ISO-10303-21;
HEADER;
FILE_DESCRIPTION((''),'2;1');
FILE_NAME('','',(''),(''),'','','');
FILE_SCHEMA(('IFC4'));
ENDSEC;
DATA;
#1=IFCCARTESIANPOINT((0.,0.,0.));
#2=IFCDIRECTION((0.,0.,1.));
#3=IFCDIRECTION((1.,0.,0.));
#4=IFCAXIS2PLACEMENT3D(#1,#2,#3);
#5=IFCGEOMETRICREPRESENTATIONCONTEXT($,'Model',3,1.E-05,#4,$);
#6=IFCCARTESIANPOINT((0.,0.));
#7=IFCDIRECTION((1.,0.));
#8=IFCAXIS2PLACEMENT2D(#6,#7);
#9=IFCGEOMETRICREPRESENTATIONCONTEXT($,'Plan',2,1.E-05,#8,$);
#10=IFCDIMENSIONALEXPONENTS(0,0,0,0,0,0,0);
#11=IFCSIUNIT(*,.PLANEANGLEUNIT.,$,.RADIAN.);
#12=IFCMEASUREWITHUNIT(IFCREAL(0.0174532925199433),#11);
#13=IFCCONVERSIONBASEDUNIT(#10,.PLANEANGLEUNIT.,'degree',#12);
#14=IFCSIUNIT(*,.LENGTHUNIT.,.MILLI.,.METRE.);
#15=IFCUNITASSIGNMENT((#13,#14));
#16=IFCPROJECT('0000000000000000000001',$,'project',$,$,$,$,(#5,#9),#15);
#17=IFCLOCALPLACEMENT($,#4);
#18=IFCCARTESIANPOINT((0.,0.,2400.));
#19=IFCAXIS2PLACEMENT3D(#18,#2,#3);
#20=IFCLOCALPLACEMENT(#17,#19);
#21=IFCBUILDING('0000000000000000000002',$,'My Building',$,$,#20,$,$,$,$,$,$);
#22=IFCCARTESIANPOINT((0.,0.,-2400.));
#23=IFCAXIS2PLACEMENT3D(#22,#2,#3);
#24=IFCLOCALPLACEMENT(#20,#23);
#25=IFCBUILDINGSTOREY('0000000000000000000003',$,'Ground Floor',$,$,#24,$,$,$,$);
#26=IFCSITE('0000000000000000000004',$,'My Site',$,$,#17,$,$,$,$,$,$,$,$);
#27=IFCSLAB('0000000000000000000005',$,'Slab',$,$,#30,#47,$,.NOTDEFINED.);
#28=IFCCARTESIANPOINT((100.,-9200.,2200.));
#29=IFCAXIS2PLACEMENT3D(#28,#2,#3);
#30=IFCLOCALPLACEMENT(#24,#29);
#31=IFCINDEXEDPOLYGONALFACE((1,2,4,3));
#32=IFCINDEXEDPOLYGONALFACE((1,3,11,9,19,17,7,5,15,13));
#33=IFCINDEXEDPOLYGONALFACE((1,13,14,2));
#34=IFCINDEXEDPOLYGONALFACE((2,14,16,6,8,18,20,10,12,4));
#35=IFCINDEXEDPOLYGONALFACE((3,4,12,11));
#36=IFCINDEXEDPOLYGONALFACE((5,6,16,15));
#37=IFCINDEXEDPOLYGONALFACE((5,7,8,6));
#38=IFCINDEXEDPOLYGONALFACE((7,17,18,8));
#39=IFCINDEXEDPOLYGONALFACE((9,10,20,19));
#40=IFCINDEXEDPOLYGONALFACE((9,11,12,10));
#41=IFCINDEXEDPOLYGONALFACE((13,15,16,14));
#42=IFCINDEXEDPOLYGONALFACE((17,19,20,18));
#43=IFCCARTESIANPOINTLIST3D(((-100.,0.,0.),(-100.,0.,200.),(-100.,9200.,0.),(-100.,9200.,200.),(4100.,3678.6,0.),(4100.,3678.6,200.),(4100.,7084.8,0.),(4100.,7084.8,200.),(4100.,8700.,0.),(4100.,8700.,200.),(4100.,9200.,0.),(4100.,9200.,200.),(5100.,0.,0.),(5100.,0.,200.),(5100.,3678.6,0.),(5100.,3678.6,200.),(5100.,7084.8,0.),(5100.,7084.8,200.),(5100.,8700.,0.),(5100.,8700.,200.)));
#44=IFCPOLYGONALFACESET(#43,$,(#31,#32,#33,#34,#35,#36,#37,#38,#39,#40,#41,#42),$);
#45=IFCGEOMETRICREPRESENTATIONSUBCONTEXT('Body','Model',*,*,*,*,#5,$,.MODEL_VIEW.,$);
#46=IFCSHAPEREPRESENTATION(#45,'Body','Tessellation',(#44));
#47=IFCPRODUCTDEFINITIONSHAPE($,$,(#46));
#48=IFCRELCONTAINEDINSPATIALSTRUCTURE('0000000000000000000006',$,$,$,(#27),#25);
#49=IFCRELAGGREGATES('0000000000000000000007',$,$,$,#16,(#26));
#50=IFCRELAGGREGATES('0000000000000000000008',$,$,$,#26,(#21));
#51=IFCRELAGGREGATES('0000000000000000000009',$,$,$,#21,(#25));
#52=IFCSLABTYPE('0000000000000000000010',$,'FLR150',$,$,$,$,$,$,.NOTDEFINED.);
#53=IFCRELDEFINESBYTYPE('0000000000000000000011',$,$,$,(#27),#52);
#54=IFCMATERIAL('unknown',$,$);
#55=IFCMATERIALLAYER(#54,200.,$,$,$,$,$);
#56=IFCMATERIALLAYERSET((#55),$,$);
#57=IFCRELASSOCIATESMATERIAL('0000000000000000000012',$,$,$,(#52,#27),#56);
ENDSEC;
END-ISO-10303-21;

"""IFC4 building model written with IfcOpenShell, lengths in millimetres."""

from ifc_helpers import new_model, entity, si_unit, converted_unit, frame, origin_with_axes, origin_2d_with_axis, place, context, subcontext, project, spatial, line, indexed_curve, outline, extrude, material, layer, layer_set, layer_usage, type_object, element, save


model = new_model("IFC4")

# Units and contexts
model_context = context("Model", 3, precision=1e-05, world=origin_with_axes())
plan_context = context("Plan", 2, precision=1e-05, world=origin_2d_with_axis())
body_context = subcontext(model_context, "Body", "Model", "MODEL_VIEW")
ifc_project = project(units=[converted_unit("PLANEANGLEUNIT", "degree", entity("IfcReal", 0.0174532925199433), si_unit("PLANEANGLEUNIT", "RADIAN"), dimensions=[0, 0, 0, 0, 0, 0, 0]), si_unit("LENGTHUNIT", "METRE", prefix="MILLI")], contexts=[model_context, plan_context])

# Site, building, storey
site_placement = place(None, origin_with_axes())
site = spatial("IfcSite", under=ifc_project, at=site_placement, Name="My Site")
building_placement = place(site_placement, frame((0.0, 0.0, 2400.0), z_axis=(0.0, 0.0, 1.0), x_axis=(1.0, 0.0, 0.0)))
building = spatial("IfcBuilding", under=site, at=building_placement, Name="My Building")
storey_placement = place(building_placement, frame((0.0, 0.0, -2400.0), z_axis=(0.0, 0.0, 1.0), x_axis=(1.0, 0.0, 0.0)))
storey = spatial("IfcBuildingStorey", under=building, at=storey_placement, Name="Ground Floor")

# Slab
ifc_material = material(Name="unknown")
ifc_layer_1 = layer(ifc_material, 200.0)
ifc_layer_set_1 = layer_set([ifc_layer_1])
slab_type_1 = type_object("IfcSlabType", Name="FLR150", PredefinedType="NOTDEFINED", material=ifc_layer_set_1)
ifc_layer_usage_1 = layer_usage(ifc_layer_set_1, "AXIS3", "POSITIVE", 0.0)
slab_1_placement = place(storey_placement, frame((100.0, -9200.0, 2200.0), z_axis=(0.0, 0.0, 1.0), x_axis=(1.0, 0.0, 0.0)))
element("IfcSlab", 1, at=slab_1_placement, inside=storey, type_object=slab_type_1, material=ifc_layer_usage_1, Name="Slab", PredefinedType="NOTDEFINED", context=body_context, shape_type="SweptSolid", body=[
    extrude(outline(indexed_curve([(-100.0, 0.0), (5100.0, 0.0), (4100.0, 8700.0), (-100.0, 9200.0), (4100.0, 9200.0), (5100.0, 8700.0), (5100.0, 3678.6), (5100.0, 7084.8), (4100.0, 7084.8), (4100.0, 3678.6)], segments=[line(8, 6), line(6, 3), line(3, 5), line(5, 4), line(4, 1), line(1, 2), line(2, 7), line(7, 10), line(10, 9), line(9, 8)], self_intersect=False)), None, (0.0, 0.0, 1.0), 200.0),
])

save(model, "model.ifc")
